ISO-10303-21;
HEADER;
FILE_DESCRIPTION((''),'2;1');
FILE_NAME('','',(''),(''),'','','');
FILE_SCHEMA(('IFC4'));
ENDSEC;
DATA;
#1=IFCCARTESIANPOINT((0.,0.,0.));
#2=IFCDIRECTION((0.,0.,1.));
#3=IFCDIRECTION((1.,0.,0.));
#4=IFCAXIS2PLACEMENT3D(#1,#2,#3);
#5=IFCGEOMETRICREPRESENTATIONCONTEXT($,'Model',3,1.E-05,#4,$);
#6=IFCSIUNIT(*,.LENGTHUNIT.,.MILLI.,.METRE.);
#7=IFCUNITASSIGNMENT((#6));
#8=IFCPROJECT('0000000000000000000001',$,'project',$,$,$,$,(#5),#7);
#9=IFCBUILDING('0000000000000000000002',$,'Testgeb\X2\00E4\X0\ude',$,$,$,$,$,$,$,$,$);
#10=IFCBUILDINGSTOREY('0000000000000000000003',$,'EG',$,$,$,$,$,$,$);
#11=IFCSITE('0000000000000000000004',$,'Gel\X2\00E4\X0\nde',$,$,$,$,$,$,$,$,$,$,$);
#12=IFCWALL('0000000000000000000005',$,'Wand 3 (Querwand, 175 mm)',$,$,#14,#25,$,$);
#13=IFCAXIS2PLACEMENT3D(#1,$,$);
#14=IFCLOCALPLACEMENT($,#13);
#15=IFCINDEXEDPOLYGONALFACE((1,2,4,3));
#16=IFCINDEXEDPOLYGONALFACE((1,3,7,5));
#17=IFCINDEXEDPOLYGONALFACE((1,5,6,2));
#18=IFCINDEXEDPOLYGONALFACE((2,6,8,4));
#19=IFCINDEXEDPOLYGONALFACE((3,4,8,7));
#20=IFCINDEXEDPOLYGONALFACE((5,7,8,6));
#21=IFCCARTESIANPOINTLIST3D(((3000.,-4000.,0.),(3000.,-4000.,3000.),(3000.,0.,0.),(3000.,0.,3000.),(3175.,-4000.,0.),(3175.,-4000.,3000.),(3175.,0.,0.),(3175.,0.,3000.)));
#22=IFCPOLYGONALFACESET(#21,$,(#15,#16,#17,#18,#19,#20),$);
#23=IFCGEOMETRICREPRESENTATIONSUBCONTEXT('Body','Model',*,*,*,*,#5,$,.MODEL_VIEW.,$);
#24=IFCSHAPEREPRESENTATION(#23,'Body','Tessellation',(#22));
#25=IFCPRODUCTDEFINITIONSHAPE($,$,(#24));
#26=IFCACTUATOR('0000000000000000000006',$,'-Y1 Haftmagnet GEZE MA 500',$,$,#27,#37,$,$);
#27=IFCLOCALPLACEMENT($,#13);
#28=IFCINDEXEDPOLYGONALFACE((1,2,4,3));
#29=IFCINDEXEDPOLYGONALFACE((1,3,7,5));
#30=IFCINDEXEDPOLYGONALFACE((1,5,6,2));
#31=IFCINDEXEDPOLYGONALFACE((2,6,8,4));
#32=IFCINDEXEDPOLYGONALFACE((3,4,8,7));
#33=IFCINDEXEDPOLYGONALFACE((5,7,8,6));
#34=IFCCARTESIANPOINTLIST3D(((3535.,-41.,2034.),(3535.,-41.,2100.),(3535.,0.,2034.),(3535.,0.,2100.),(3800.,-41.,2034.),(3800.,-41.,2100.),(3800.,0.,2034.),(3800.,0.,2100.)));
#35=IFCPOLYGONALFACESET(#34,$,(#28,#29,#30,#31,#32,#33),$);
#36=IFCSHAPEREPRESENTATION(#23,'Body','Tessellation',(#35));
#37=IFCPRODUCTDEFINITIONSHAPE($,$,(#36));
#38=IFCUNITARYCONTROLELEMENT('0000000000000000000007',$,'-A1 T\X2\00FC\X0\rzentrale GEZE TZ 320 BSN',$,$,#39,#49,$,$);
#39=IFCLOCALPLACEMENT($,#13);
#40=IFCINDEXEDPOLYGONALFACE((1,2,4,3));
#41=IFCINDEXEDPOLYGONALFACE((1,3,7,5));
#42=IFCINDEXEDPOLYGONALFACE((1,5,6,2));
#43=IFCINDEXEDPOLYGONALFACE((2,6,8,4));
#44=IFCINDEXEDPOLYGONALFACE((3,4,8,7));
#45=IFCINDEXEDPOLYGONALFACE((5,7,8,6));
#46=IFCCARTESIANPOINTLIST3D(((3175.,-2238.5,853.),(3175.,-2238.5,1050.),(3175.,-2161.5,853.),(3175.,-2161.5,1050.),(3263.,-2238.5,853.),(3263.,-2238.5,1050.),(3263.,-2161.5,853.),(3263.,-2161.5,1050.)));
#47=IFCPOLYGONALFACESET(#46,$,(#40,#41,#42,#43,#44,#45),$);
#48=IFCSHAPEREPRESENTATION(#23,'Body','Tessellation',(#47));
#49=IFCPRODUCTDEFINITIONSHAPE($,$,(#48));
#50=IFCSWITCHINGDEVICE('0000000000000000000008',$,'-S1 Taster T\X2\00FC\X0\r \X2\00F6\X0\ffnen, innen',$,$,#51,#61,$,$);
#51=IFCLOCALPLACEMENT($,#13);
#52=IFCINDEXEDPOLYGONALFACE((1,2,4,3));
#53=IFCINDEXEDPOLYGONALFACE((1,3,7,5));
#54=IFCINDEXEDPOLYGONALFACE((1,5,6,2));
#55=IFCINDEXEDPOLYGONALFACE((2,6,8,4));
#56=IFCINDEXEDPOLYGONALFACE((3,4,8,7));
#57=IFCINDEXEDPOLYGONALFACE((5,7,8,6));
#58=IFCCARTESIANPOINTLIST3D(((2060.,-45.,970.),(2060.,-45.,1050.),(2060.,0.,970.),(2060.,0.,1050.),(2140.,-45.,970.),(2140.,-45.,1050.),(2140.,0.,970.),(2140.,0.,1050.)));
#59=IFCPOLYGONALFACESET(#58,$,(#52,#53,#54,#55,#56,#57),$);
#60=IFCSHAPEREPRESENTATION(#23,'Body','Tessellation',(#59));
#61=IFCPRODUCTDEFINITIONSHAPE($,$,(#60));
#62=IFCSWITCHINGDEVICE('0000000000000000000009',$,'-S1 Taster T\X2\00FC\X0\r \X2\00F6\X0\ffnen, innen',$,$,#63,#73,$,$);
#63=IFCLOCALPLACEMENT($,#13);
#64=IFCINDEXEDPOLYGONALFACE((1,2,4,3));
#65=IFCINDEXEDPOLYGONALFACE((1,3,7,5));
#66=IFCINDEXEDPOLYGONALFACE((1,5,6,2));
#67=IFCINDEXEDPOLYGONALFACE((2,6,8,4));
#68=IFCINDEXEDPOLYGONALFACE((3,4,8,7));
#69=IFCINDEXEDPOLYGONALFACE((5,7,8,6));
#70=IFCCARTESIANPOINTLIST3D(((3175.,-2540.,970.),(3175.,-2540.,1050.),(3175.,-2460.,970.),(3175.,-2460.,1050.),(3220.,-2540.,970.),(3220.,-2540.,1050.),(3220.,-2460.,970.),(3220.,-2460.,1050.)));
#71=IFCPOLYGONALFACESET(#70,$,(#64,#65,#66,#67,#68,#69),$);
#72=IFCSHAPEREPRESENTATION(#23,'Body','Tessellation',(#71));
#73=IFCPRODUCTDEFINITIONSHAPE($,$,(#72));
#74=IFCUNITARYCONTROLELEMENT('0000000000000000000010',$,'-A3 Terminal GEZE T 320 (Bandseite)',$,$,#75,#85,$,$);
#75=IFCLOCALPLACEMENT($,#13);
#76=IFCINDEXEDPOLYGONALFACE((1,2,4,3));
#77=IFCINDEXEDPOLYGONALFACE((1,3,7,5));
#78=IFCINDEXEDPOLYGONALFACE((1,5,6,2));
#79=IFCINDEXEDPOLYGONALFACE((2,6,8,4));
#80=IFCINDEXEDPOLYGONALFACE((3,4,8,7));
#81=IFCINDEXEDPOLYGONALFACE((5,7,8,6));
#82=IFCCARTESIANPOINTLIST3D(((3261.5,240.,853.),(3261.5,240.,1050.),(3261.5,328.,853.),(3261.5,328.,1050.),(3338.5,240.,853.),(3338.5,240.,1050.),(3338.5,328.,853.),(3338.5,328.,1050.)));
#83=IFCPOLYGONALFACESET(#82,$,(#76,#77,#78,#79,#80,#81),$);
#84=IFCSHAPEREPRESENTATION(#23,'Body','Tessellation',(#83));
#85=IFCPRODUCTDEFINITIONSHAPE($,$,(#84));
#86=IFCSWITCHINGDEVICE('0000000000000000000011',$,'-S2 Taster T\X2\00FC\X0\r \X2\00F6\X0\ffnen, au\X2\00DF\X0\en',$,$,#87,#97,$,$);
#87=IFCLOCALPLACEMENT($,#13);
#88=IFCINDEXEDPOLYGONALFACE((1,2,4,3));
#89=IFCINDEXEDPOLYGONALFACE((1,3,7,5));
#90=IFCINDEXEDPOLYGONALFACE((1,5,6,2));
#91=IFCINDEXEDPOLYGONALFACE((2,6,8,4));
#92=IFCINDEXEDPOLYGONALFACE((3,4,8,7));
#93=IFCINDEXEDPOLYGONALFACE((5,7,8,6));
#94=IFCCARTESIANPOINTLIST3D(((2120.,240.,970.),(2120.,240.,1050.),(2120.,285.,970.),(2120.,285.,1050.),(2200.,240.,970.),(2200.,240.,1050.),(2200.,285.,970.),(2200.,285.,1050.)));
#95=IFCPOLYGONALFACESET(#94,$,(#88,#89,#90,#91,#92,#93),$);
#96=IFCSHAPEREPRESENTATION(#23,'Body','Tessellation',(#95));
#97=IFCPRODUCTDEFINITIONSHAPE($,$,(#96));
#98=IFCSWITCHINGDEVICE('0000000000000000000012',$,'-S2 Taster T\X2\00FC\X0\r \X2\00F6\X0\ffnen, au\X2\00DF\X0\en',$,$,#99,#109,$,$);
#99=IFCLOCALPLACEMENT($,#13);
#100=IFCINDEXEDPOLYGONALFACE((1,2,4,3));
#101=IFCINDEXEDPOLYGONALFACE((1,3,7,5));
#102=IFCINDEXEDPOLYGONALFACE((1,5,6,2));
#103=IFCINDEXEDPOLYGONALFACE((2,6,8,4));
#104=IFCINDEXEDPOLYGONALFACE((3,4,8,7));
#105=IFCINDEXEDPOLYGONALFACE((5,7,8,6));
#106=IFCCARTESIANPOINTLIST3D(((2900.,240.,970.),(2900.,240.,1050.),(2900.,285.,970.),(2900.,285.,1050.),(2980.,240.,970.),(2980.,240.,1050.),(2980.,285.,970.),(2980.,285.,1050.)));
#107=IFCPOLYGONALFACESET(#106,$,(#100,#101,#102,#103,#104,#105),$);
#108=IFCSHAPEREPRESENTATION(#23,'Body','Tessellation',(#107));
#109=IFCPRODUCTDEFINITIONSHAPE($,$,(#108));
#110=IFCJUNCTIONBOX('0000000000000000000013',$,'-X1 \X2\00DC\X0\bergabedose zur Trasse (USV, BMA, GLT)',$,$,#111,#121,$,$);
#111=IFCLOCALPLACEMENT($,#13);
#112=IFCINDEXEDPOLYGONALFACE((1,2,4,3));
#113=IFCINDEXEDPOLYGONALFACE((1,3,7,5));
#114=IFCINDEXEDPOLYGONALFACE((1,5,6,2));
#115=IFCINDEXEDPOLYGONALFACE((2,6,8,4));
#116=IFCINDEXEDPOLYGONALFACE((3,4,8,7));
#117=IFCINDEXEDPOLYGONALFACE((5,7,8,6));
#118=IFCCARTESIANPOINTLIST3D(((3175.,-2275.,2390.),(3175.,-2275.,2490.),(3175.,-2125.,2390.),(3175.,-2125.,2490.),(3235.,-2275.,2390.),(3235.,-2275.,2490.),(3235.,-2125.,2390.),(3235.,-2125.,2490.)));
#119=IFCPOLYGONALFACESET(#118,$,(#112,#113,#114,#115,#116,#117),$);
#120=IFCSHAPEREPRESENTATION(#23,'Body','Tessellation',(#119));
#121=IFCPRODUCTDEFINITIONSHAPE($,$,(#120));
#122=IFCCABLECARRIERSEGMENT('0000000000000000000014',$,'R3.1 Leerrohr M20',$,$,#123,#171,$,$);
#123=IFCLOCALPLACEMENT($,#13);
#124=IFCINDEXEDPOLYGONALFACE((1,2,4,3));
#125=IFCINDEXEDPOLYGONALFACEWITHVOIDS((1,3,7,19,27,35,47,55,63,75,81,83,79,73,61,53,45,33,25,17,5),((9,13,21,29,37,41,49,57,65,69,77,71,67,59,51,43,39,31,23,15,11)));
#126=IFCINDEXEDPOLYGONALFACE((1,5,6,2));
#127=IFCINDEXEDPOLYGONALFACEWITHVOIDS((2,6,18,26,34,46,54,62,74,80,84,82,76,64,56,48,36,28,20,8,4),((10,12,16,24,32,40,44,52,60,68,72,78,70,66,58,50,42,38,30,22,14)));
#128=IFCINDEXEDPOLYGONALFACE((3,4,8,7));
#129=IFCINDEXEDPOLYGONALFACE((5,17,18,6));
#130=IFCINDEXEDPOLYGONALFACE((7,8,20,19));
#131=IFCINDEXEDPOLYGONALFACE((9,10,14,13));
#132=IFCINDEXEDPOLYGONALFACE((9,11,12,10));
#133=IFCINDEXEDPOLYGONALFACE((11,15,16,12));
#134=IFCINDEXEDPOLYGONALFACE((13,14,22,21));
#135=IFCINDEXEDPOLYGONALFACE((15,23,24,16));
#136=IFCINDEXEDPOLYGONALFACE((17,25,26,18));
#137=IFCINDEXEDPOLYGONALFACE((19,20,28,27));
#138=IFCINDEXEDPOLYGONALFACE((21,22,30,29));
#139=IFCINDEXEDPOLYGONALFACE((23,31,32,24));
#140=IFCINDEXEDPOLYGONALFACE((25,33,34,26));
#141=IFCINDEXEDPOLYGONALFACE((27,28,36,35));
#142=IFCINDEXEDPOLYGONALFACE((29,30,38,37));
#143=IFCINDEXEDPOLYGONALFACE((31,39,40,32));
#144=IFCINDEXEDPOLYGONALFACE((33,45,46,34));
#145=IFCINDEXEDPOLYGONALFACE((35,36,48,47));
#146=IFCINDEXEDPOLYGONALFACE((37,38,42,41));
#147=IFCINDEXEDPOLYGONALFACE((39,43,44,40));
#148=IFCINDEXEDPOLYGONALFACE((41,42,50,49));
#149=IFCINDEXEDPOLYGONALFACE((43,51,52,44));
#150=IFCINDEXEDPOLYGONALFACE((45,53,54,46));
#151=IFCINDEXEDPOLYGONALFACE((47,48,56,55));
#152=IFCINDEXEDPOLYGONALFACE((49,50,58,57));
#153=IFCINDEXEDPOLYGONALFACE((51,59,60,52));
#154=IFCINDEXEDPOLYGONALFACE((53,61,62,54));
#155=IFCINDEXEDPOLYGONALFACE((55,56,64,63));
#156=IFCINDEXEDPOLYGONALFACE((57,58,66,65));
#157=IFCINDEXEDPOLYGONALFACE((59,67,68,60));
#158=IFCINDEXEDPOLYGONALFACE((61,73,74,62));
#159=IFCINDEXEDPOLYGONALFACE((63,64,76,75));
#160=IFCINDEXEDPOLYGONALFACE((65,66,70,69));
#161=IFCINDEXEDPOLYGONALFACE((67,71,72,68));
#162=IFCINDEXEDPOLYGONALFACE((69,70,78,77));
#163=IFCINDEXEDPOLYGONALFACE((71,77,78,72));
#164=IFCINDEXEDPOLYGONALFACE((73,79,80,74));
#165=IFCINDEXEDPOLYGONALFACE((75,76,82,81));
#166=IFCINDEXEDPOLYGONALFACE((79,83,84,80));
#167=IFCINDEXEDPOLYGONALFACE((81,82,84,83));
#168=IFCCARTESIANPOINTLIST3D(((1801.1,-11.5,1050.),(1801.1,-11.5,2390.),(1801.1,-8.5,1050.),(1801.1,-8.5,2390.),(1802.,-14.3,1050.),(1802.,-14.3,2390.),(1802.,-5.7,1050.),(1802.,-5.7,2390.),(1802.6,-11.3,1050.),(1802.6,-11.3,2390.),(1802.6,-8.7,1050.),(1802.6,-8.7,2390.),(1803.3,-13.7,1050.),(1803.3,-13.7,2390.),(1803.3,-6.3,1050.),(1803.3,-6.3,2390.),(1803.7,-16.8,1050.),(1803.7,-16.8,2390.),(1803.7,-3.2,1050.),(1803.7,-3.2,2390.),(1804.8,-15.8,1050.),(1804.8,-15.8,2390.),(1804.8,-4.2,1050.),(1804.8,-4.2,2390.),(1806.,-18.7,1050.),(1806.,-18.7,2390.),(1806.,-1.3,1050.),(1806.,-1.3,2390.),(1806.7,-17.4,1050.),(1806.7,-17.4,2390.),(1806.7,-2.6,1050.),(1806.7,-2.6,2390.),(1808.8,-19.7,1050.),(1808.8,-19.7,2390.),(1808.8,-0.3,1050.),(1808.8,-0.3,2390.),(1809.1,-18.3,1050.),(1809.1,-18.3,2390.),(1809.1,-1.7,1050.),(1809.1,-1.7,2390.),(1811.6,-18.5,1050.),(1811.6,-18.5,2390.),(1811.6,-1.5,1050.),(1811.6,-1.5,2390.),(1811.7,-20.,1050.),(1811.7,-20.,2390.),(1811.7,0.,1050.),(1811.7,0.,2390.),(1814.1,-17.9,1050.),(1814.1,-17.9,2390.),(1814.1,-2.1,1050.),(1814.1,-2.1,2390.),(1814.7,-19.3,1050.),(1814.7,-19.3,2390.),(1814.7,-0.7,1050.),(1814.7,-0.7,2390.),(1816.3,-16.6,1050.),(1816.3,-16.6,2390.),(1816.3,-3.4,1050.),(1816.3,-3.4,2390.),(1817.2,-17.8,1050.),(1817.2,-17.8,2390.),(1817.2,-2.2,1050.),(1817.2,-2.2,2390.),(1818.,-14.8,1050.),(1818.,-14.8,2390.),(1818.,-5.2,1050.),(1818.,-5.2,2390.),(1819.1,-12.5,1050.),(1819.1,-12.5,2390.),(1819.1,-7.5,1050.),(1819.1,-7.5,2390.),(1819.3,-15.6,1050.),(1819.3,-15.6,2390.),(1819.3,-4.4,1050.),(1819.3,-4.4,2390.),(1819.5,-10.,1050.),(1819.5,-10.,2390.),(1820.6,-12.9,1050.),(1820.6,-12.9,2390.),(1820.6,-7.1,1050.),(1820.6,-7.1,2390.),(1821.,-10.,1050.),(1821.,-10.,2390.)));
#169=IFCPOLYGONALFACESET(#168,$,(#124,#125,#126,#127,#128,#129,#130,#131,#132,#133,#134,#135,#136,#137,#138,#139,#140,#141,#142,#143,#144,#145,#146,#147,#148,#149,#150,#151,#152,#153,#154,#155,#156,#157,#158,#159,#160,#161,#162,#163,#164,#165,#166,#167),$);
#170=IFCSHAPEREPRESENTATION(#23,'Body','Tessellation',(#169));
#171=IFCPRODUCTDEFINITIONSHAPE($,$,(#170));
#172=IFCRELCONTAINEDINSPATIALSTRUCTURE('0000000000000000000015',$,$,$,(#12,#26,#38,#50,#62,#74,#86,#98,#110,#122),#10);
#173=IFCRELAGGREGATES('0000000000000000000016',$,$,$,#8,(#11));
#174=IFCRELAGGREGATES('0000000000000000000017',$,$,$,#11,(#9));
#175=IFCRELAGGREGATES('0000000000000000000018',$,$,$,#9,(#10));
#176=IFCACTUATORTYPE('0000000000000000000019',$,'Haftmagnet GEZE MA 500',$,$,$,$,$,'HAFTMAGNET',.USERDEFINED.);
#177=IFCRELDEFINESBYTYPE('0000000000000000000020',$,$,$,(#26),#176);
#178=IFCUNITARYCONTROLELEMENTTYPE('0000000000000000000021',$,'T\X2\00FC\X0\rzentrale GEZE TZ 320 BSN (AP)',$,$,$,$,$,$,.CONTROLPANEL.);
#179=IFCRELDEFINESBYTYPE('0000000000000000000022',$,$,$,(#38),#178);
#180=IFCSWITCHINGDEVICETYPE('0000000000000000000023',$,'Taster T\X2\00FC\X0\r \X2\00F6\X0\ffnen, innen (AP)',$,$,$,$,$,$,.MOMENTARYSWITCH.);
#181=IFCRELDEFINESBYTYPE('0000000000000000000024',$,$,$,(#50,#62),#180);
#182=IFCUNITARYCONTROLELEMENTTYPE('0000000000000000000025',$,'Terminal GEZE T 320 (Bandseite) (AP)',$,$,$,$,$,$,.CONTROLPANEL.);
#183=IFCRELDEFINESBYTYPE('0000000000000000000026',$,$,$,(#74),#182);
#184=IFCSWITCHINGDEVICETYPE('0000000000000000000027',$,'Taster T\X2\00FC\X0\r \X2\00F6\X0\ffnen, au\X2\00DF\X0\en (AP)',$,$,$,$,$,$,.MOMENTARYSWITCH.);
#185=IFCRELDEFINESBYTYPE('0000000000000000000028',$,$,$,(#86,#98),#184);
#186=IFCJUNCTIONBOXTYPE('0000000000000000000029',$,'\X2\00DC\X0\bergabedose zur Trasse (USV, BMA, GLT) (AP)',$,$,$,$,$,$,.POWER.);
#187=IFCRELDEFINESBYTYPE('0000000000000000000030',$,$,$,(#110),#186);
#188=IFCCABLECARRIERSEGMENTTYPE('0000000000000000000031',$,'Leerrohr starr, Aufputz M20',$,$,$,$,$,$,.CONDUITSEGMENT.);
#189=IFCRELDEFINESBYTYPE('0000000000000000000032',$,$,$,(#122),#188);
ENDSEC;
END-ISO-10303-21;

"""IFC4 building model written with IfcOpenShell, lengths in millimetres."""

from ifc_helpers import new_model, si_unit, frame, frame_2d, origin_with_axes, place, context, subcontext, project, spatial, rectangle, hollow_circle, extrude, type_object, element, save


model = new_model("IFC4")

# Units and contexts
model_context = context("Model", 3, precision=1e-05, world=origin_with_axes())
body_context = subcontext(model_context, "Body", "Model", "MODEL_VIEW")
ifc_project = project(units=[si_unit("LENGTHUNIT", "METRE", prefix="MILLI")], contexts=[model_context])

# Site, building, storey
site = spatial("IfcSite", under=ifc_project, Name="Gelände")
building = spatial("IfcBuilding", under=site, Name="Testgebäude")
storey = spatial("IfcBuildingStorey", under=building, Name="EG")

# Wall
wall_placement = place(None, frame((3000.0, 0.0, 0.0), z_axis=(0.0, 0.0, 1.0), x_axis=(0.0, -1.0, 0.0)))
element("IfcWall", 1, at=wall_placement, inside=storey, Name="Wand 3 (Querwand, 175 mm)", context=body_context, shape_type="SweptSolid", body=[
    extrude(rectangle(XDim=4000.0, YDim=175.0, at=frame_2d((2000.0, 87.5))), None, (0.0, 0.0, 1.0), 3000.0),
])

# Actuator
actuator_type = type_object("IfcActuatorType", Name="Haftmagnet GEZE MA 500", ElementType="HAFTMAGNET", PredefinedType="USERDEFINED")
actuator_placement = place(None, frame((3535.0, -41.0, 2034.0), z_axis=(0.0, 0.0, 1.0), x_axis=(1.0, 0.0, 0.0)))
element("IfcActuator", 2, at=actuator_placement, inside=storey, type_object=actuator_type, Name="-Y1 Haftmagnet GEZE MA 500", context=body_context, shape_type="SweptSolid", body=[
    extrude(rectangle(XDim=265.0, YDim=41.0, at=frame_2d((132.5, 20.5))), None, (0.0, 0.0, 1.0), 66.0),
])

# Unitary control element
unitary_control_element_type_1 = type_object("IfcUnitaryControlElementType", Name="Türzentrale GEZE TZ 320 BSN (AP)", PredefinedType="CONTROLPANEL")
unitary_control_element_1_placement = place(None, frame((3175.0, -2238.5, 853.0), z_axis=(0.0, 0.0, 1.0), x_axis=(1.0, 0.0, 0.0)))
element("IfcUnitaryControlElement", 3, at=unitary_control_element_1_placement, inside=storey, type_object=unitary_control_element_type_1, Name="-A1 Türzentrale GEZE TZ 320 BSN", context=body_context, shape_type="SweptSolid", body=[
    extrude(rectangle(XDim=88.0, YDim=77.0, at=frame_2d((44.0, 38.5))), None, (0.0, 0.0, 1.0), 197.0),
])

# Switching devices
switching_device_type_1 = type_object("IfcSwitchingDeviceType", Name="Taster Tür öffnen, innen (AP)", PredefinedType="MOMENTARYSWITCH")
switching_device_1_placement = place(None, frame((2060.0, -45.0, 970.0), z_axis=(0.0, 0.0, 1.0), x_axis=(1.0, 0.0, 0.0)))
element("IfcSwitchingDevice", 4, at=switching_device_1_placement, inside=storey, type_object=switching_device_type_1, Name="-S1 Taster Tür öffnen, innen", context=body_context, shape_type="SweptSolid", body=[
    extrude(rectangle(XDim=80.0, YDim=45.0, at=frame_2d((40.0, 22.5))), None, (0.0, 0.0, 1.0), 80.0),
])
switching_device_2_placement = place(None, frame((3175.0, -2540.0, 970.0), z_axis=(0.0, 0.0, 1.0), x_axis=(1.0, 0.0, 0.0)))
element("IfcSwitchingDevice", 5, at=switching_device_2_placement, inside=storey, type_object=switching_device_type_1, Name="-S1 Taster Tür öffnen, innen", context=body_context, shape_type="SweptSolid", body=[
    extrude(rectangle(XDim=45.0, YDim=80.0, at=frame_2d((22.5, 40.0))), None, (0.0, 0.0, 1.0), 80.0),
])

# Unitary control element
unitary_control_element_type_2 = type_object("IfcUnitaryControlElementType", Name="Terminal GEZE T 320 (Bandseite) (AP)", PredefinedType="CONTROLPANEL")
unitary_control_element_2_placement = place(None, frame((3261.5, 240.0, 853.0), z_axis=(0.0, 0.0, 1.0), x_axis=(1.0, 0.0, 0.0)))
element("IfcUnitaryControlElement", 6, at=unitary_control_element_2_placement, inside=storey, type_object=unitary_control_element_type_2, Name="-A3 Terminal GEZE T 320 (Bandseite)", context=body_context, shape_type="SweptSolid", body=[
    extrude(rectangle(XDim=77.0, YDim=88.0, at=frame_2d((38.5, 44.0))), None, (0.0, 0.0, 1.0), 197.0),
])

# Switching devices
switching_device_type_2 = type_object("IfcSwitchingDeviceType", Name="Taster Tür öffnen, außen (AP)", PredefinedType="MOMENTARYSWITCH")
for number, where, z_axis, x_axis, name in (
    (7, (2120.0, 240.0, 970.0), (0.0, 0.0, 1.0), (1.0, 0.0, 0.0), "-S2 Taster Tür öffnen, außen"),
    (8, (2900.0, 240.0, 970.0), (0.0, 0.0, 1.0), (1.0, 0.0, 0.0), "-S2 Taster Tür öffnen, außen"),
):
    element("IfcSwitchingDevice", number, at=place(None, frame(where, z_axis=z_axis, x_axis=x_axis)), inside=storey, type_object=switching_device_type_2, Name=name, context=body_context, shape_type="SweptSolid", body=[
        extrude(rectangle(XDim=80.0, YDim=45.0, at=frame_2d((40.0, 22.5))), None, (0.0, 0.0, 1.0), 80.0),
    ])

# Junction box
junction_box_type = type_object("IfcJunctionBoxType", Name="Übergabedose zur Trasse (USV, BMA, GLT) (AP)", PredefinedType="POWER")
junction_box_placement = place(None, frame((3175.0, -2275.0, 2390.0), z_axis=(0.0, 0.0, 1.0), x_axis=(1.0, 0.0, 0.0)))
element("IfcJunctionBox", 9, at=junction_box_placement, inside=storey, type_object=junction_box_type, Name="-X1 Übergabedose zur Trasse (USV, BMA, GLT)", context=body_context, shape_type="SweptSolid", body=[
    extrude(rectangle(XDim=60.0, YDim=150.0, at=frame_2d((30.0, 75.0))), None, (0.0, 0.0, 1.0), 100.0),
])

# Cable carrier segment
cable_carrier_segment_type_1 = type_object("IfcCableCarrierSegmentType", Name="Leerrohr starr, Aufputz M20", PredefinedType="CONDUITSEGMENT")
for number, where, z_axis, x_axis, name in (
    (10, (1811.0, -10.0, 1050.0), (0.0, 0.0, 1.0), (1.0, 0.0, 0.0), "R3.1 Leerrohr M20"),
):
    element("IfcCableCarrierSegment", number, at=place(None, frame(where, z_axis=z_axis, x_axis=x_axis)), inside=storey, type_object=cable_carrier_segment_type_1, Name=name, context=body_context, shape_type="SweptSolid", body=[
        extrude(hollow_circle(Radius=10.0, WallThickness=1.5), None, (0.0, 0.0, 1.0), 1340.0),
    ])

save(model, "model.ifc")
